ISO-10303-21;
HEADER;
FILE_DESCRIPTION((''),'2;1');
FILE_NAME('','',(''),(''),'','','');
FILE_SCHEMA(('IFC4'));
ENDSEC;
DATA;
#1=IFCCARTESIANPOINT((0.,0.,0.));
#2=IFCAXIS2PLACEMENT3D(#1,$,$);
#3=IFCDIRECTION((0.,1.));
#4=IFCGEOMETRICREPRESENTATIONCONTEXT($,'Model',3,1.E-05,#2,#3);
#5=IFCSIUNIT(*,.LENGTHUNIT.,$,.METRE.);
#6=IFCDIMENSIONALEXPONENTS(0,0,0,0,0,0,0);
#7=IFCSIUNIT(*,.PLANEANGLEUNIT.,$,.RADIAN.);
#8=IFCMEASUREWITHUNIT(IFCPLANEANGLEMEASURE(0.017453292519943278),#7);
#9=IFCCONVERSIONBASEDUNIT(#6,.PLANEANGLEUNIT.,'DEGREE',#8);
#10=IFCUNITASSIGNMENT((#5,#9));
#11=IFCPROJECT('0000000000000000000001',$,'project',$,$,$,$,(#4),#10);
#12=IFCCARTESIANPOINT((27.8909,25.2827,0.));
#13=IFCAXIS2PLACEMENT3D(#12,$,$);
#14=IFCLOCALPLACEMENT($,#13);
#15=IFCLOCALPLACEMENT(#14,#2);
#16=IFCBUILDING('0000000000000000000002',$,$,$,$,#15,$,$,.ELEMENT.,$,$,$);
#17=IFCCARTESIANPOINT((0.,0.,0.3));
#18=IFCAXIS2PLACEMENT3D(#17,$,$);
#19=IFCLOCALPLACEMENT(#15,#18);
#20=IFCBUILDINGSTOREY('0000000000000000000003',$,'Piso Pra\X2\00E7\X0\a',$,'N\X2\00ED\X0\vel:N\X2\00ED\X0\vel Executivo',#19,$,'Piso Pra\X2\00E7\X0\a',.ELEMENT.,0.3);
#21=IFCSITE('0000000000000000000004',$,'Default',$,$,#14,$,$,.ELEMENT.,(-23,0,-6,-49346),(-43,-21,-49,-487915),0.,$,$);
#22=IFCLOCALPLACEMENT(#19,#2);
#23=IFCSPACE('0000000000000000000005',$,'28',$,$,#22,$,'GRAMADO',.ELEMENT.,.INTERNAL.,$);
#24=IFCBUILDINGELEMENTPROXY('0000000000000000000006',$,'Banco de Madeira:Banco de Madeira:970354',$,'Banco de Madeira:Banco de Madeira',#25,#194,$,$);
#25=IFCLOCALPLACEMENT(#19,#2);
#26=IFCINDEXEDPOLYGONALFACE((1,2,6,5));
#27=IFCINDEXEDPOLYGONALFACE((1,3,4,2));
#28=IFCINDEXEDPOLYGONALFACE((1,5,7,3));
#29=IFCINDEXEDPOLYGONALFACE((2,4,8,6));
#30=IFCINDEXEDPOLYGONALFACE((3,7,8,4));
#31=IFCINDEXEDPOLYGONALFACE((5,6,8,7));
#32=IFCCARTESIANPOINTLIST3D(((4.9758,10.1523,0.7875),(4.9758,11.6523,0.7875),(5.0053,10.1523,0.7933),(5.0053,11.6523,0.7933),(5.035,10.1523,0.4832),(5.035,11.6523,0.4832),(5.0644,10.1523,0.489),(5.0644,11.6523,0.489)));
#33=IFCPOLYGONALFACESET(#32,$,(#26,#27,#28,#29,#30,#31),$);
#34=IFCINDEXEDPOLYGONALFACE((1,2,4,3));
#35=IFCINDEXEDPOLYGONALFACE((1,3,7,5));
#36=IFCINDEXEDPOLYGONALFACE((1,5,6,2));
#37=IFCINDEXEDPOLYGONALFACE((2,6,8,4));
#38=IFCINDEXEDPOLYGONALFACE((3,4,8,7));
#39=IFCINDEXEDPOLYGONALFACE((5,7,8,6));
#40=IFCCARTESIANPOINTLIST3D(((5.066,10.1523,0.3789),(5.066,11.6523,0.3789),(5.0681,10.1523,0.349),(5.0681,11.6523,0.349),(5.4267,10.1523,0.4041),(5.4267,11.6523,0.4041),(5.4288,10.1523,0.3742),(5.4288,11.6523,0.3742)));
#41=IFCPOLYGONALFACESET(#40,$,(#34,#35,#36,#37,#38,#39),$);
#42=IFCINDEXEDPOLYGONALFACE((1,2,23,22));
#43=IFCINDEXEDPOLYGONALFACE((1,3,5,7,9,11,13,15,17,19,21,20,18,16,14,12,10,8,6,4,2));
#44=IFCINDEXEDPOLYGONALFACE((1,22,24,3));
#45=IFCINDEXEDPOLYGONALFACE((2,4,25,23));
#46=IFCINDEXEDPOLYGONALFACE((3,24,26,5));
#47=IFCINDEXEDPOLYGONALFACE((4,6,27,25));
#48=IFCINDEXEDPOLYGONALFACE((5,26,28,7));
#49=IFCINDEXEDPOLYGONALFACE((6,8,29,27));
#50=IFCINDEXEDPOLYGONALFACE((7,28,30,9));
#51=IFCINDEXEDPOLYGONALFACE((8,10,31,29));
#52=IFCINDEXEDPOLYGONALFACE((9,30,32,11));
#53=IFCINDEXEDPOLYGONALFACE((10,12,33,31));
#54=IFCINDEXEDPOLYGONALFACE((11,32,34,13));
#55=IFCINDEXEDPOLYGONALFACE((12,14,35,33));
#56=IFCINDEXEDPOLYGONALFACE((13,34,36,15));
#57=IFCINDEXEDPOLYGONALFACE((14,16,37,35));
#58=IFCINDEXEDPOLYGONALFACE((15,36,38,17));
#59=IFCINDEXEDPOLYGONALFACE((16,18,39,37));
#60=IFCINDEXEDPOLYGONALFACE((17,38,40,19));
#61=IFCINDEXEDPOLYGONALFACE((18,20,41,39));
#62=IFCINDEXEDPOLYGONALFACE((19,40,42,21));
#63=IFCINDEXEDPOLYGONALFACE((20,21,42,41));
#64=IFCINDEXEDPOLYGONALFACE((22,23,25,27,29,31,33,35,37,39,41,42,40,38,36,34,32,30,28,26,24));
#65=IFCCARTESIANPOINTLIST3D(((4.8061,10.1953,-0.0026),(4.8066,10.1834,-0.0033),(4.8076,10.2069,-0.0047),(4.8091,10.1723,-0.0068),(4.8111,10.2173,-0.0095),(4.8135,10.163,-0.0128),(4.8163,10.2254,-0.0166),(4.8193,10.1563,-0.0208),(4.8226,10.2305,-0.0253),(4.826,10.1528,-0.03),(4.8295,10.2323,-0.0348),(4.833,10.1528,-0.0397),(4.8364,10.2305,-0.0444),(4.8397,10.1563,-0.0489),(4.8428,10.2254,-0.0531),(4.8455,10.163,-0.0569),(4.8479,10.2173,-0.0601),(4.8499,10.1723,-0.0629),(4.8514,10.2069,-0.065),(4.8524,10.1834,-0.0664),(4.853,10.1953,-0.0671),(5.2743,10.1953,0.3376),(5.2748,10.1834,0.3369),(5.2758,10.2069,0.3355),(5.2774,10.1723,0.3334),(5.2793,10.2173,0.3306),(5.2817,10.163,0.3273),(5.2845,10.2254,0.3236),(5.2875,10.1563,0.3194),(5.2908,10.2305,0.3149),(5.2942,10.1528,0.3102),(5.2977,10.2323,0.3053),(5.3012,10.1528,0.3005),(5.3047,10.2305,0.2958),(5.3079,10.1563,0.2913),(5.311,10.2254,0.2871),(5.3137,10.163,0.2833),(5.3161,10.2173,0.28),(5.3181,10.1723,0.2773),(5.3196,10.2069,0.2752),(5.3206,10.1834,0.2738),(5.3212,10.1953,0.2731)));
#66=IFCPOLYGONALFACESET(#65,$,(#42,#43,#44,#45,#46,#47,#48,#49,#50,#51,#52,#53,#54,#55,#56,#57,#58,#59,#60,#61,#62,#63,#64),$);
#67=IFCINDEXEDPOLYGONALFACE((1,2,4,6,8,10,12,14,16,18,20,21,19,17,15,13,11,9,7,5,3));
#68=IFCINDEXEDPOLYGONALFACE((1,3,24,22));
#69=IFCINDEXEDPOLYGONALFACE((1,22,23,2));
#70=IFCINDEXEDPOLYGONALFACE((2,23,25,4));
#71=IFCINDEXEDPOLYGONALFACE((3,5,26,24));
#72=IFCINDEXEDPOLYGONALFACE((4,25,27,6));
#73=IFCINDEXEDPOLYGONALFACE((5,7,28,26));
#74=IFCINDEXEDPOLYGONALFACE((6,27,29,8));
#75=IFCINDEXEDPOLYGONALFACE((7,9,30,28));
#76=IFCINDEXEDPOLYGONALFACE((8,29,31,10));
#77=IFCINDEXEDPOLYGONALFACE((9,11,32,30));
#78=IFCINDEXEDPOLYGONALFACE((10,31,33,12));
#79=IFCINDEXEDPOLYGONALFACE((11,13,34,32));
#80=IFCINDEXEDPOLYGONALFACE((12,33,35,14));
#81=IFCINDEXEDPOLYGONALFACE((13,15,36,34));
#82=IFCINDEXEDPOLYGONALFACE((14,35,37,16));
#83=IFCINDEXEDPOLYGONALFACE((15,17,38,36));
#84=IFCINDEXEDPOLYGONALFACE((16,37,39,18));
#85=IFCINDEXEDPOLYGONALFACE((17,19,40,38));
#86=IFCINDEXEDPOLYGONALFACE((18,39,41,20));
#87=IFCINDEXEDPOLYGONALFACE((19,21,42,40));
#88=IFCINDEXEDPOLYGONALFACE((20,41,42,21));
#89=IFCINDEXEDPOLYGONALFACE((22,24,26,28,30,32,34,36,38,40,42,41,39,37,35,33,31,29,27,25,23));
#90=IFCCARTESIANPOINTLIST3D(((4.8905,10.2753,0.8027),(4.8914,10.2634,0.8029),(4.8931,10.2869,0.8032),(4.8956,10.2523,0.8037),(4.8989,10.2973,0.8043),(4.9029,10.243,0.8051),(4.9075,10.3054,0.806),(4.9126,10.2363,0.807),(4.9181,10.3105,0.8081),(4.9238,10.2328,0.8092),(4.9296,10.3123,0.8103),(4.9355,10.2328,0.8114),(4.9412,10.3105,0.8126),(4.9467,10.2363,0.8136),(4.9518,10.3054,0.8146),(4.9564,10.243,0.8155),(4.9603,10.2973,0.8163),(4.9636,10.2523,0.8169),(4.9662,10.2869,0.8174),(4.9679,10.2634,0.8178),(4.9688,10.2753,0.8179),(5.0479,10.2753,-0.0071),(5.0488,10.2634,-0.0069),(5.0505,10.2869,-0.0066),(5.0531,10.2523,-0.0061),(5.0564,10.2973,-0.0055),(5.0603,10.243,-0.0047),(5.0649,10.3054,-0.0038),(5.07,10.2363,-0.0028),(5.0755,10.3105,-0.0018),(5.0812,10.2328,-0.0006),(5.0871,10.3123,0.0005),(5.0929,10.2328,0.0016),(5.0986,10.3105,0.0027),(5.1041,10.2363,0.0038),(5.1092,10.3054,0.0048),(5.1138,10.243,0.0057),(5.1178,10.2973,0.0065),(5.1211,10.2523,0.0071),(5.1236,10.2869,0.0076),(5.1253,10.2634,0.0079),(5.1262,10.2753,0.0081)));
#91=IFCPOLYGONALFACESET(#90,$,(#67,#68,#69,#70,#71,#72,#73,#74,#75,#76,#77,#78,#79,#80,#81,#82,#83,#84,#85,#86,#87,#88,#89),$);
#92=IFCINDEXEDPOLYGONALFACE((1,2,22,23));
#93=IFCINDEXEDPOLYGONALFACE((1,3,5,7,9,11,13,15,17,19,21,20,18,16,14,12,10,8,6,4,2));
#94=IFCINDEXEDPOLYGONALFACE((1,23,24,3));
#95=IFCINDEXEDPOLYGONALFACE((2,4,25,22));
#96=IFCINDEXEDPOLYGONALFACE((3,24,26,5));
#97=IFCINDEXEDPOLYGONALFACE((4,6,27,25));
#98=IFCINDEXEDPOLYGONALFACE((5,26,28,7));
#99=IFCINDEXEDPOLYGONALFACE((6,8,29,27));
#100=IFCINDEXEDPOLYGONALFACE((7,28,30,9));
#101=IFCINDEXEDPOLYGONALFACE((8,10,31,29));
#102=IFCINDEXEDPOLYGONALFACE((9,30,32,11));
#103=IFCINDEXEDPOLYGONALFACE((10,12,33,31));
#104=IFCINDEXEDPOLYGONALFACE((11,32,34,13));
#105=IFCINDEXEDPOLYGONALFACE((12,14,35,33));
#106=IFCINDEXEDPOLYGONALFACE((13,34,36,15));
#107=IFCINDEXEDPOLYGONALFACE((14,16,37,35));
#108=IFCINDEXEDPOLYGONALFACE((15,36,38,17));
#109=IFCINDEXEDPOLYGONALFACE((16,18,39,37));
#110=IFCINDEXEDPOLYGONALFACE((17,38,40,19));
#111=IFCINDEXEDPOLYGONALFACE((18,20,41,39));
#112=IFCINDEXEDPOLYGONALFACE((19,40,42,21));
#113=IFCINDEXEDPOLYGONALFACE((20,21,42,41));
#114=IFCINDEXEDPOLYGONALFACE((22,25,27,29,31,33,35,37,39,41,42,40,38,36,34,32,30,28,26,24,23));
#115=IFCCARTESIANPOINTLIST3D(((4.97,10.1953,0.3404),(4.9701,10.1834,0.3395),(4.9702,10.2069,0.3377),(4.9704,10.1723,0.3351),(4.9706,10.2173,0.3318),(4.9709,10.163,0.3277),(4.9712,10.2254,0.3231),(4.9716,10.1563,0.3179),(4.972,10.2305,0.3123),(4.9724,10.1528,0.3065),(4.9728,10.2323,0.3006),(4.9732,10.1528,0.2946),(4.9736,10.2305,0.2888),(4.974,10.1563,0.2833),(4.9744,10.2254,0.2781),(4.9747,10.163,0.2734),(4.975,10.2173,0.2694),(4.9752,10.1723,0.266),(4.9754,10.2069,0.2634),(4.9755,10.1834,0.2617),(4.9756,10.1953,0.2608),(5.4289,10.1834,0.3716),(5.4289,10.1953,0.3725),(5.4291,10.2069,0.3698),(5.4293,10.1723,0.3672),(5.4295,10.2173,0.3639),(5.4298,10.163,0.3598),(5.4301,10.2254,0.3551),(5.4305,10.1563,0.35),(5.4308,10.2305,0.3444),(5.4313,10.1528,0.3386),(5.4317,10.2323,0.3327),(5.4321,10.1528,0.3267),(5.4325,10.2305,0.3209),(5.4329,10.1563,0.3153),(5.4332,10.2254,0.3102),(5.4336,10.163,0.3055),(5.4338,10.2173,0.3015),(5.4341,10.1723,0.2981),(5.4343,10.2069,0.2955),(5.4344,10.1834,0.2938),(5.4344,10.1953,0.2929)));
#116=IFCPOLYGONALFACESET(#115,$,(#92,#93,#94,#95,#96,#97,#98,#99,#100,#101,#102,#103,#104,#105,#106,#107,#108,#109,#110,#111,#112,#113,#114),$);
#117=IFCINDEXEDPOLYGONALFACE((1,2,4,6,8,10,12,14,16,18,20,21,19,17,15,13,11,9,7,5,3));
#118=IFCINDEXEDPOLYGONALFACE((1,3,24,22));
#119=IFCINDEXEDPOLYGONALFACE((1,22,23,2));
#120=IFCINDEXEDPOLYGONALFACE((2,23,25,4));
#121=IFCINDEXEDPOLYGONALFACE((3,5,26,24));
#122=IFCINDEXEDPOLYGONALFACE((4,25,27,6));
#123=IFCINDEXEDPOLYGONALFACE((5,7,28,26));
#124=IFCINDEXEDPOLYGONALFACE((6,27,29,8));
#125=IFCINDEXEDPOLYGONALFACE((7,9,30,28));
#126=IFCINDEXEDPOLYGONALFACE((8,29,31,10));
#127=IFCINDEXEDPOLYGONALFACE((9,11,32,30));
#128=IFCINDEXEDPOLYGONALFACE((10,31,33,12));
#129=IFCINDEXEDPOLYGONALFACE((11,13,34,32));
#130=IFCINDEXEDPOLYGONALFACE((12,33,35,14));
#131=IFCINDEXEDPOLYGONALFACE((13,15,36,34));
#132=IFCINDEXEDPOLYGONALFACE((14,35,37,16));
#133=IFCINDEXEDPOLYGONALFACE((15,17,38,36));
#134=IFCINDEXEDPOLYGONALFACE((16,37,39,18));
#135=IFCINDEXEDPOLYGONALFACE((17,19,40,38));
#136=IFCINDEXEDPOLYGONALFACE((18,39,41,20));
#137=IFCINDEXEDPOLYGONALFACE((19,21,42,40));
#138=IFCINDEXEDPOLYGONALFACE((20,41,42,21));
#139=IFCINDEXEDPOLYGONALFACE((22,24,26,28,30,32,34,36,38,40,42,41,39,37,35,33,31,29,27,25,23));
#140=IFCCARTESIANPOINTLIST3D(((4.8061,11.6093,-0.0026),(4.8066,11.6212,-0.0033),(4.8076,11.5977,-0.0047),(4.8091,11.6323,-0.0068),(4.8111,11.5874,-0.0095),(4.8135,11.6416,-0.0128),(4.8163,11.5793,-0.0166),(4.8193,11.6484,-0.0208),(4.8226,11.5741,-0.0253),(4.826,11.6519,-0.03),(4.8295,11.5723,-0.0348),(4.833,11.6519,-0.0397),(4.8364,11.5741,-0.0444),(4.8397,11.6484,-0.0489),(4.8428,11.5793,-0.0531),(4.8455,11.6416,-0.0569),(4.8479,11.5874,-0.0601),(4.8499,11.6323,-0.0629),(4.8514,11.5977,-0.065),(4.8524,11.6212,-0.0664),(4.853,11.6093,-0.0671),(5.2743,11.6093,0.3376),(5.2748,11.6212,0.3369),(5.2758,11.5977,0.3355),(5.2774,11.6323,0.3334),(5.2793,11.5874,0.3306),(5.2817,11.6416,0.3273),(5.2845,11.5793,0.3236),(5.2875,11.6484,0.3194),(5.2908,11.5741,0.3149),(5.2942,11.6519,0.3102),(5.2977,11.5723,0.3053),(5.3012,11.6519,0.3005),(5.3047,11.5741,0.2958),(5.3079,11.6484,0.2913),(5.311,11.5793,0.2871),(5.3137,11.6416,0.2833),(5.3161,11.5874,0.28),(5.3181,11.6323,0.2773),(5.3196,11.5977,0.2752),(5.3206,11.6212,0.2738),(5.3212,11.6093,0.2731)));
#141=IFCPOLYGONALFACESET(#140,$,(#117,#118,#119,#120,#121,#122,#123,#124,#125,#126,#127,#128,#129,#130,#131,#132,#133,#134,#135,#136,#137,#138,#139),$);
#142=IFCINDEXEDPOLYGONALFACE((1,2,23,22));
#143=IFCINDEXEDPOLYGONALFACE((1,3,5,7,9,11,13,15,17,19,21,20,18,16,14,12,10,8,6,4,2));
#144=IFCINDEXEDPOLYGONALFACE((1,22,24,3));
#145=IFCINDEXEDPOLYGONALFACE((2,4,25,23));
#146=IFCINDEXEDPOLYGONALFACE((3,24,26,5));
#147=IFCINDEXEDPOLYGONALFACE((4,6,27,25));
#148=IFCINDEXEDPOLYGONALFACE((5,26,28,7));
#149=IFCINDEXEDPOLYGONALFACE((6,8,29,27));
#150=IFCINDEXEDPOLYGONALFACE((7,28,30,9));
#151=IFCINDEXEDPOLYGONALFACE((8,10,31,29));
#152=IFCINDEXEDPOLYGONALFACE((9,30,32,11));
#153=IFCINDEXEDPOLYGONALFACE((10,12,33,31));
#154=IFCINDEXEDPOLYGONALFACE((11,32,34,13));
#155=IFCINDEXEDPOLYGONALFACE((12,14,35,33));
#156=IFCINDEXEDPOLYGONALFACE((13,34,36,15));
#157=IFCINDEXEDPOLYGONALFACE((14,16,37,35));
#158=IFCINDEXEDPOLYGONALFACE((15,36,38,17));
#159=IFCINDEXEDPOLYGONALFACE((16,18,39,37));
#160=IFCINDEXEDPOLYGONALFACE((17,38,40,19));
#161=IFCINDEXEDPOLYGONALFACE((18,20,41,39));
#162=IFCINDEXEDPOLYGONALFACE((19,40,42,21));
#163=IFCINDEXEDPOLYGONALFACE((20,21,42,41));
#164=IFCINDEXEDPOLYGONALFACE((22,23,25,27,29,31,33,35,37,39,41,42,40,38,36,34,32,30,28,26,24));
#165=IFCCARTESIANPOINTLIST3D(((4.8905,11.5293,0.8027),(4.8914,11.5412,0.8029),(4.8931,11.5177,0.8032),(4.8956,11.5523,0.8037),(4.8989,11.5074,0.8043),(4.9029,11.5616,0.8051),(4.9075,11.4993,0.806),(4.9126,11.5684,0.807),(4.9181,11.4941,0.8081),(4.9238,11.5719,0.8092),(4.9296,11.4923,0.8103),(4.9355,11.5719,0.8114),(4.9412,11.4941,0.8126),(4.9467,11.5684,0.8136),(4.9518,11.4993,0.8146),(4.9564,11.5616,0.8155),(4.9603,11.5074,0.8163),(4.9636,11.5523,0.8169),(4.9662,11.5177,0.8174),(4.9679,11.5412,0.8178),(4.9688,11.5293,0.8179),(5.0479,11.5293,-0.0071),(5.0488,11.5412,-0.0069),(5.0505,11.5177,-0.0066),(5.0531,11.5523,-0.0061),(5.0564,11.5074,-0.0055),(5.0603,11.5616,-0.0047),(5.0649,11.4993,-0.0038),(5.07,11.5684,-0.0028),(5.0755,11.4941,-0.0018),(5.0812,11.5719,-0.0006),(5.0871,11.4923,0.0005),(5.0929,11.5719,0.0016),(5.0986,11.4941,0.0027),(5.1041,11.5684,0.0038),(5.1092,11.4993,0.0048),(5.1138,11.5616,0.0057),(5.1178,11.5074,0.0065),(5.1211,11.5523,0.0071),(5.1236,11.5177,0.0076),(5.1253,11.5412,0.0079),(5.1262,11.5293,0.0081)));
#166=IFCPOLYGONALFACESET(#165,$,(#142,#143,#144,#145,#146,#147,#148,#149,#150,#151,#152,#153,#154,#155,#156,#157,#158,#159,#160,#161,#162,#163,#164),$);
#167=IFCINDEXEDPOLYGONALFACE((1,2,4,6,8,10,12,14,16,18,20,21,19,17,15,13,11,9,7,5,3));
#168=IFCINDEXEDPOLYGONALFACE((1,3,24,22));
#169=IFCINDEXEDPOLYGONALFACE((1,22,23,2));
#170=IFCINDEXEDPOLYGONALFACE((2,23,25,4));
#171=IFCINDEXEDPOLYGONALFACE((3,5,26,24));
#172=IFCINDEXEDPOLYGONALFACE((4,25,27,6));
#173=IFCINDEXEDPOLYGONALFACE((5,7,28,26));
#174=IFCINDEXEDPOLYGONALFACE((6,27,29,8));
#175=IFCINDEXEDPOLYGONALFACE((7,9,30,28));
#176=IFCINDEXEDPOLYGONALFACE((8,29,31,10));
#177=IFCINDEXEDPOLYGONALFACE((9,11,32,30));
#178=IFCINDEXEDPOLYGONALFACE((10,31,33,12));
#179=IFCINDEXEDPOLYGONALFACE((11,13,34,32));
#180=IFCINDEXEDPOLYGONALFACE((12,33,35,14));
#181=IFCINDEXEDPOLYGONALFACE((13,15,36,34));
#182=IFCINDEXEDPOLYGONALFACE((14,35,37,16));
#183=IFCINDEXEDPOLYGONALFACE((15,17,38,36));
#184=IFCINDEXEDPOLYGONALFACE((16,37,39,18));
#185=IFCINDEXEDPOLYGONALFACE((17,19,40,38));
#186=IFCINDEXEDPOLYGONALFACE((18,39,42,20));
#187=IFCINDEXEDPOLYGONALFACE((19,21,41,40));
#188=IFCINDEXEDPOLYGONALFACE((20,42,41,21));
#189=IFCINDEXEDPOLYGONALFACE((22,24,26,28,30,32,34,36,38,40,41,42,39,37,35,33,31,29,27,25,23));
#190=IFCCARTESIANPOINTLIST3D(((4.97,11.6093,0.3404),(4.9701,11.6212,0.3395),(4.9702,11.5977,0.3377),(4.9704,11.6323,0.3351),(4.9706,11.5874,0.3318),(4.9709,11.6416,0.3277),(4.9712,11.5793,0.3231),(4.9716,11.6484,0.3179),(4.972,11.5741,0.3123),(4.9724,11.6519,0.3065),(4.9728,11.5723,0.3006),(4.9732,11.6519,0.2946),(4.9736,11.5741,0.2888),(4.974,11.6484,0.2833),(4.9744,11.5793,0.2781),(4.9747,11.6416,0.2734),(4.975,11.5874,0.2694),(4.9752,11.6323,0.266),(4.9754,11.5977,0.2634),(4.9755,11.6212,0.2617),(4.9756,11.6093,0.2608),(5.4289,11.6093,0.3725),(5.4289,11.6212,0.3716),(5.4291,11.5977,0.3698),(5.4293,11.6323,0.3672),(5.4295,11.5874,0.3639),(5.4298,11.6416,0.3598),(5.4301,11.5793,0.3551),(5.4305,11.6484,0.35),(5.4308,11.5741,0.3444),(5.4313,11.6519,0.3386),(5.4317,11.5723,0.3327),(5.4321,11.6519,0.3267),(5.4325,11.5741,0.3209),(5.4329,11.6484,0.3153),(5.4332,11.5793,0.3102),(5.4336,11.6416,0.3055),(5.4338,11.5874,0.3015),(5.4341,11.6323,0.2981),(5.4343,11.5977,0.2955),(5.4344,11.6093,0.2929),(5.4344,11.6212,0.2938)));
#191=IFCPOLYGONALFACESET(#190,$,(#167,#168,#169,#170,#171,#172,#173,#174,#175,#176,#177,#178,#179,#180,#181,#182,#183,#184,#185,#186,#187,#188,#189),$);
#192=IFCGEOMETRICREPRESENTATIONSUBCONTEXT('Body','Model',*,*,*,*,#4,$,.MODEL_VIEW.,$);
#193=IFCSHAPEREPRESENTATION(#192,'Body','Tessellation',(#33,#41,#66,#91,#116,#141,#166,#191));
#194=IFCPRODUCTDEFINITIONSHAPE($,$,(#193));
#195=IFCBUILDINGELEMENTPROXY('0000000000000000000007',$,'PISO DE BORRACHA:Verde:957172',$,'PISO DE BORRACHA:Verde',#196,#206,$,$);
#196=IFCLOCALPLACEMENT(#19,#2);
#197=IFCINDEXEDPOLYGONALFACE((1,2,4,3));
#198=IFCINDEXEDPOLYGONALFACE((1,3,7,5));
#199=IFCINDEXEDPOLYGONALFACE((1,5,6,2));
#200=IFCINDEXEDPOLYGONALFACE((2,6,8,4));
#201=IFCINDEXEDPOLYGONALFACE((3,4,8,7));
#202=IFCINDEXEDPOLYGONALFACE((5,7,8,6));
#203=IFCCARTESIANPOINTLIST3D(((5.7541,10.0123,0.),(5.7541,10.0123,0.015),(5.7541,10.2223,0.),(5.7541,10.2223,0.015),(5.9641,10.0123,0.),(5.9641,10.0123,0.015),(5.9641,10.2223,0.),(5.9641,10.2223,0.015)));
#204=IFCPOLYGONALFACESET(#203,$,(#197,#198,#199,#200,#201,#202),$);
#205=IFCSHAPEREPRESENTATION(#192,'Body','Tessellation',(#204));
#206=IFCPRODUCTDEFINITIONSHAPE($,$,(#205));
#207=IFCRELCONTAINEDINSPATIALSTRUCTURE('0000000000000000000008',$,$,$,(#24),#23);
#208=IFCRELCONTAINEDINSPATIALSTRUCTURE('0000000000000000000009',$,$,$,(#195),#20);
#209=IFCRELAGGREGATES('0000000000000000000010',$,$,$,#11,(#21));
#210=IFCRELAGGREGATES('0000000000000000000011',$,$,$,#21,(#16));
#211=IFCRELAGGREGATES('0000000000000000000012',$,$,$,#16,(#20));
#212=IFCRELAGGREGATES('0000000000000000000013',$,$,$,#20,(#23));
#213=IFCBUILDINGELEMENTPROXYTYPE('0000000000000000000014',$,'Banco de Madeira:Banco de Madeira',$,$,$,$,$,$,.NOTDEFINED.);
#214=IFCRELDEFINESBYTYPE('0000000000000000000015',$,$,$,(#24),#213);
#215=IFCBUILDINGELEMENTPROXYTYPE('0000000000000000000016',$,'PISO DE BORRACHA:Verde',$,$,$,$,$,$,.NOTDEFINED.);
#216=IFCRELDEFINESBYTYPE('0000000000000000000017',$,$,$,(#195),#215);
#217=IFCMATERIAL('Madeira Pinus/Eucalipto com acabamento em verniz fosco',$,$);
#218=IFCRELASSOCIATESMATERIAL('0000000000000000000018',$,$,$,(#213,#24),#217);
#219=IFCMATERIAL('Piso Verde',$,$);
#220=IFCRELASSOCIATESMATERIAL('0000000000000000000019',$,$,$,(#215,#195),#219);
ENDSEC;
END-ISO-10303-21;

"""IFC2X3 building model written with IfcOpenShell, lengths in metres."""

from ifc_helpers import new_model, entity, si_unit, converted_unit, direction, frame, frame_2d, origin, origin_2d_with_axis, place, context, subcontext, project, spatial, rectangle, circle, extrude, source, transform, mapped, material, type_object, type_shapes, element, save


model = new_model("IFC2X3")

# Units and contexts
model_context = context("Model", 3, precision=1e-05, world=origin(), true_north=direction((0.0, 1.0)))
body_context = subcontext(model_context, "Body", "Model", "MODEL_VIEW")
ifc_project = project(units=[si_unit("LENGTHUNIT", "METRE"), converted_unit("PLANEANGLEUNIT", "DEGREE", entity("IfcPlaneAngleMeasure", 0.017453292519943278), si_unit("PLANEANGLEUNIT", "RADIAN"), dimensions=[0, 0, 0, 0, 0, 0, 0])], contexts=[model_context])

# Site, building, storey
site_placement = place(None, frame((27.8909, 25.2827, 0.0)))
site = spatial("IfcSite", under=ifc_project, at=site_placement, Name="Default", CompositionType="ELEMENT", RefLatitude=(-23, 0, -6, -49346), RefLongitude=(-43, -21, -49, -487915), RefElevation=0.0)
building_placement = place(site_placement, origin())
building = spatial("IfcBuilding", under=site, at=building_placement, CompositionType="ELEMENT")
storey_placement = place(building_placement, frame((0.0, 0.0, 0.3)))
storey = spatial("IfcBuildingStorey", under=building, at=storey_placement, Name="Piso Praça", ObjectType="Nível:Nível Executivo", LongName="Piso Praça", CompositionType="ELEMENT", Elevation=0.3)

# Shared definitions
space_placement = place(storey_placement, origin())
space = spatial("IfcSpace", under=storey, at=space_placement, Name="28", LongName="GRAMADO", CompositionType="ELEMENT", InteriorOrExteriorSpace="INTERNAL")

# Building element proxies
ifc_material_1 = material(Name="Madeira Pinus/Eucalipto com acabamento em verniz fosco")
building_element_proxy_type_1 = type_object("IfcBuildingElementProxyType", Name="Banco de Madeira:Banco de Madeira", PredefinedType="NOTDEFINED", material=ifc_material_1)
shared_shape_1 = source(origin(), body_context, "Body", "SweptSolid", [
    extrude(rectangle(XDim=0.31, YDim=0.03, at=frame_2d((0.0, 0.0), x_axis=(0.0, 1.0))), frame((-0.75, -0.1439, 0.6383), z_axis=(1.0, 0.0, 0.0), x_axis=(0.0, 0.981627, 0.190809)), (0.0, 0.0, 1.0), 1.5),
    extrude(rectangle(XDim=0.03, YDim=0.3616, at=frame_2d((0.0, 0.0), x_axis=(1.0, 0.0))), frame((-0.75, 0.0833, 0.3765), z_axis=(1.0, 0.0, 0.0), x_axis=(0.0, -0.069756, 0.997564)), (0.0, 0.0, 1.0), 1.5),
    extrude(circle(Radius=0.04, at=frame_2d((0.0, 0.0), x_axis=(1.0, 0.0))), frame((0.71, -0.3345, -0.0348), z_axis=(0.0, 0.809017, 0.587785), x_axis=(-1.0, 0.0, 0.0)), (0.0, 0.0, 1.0), 0.5788),
    extrude(circle(Radius=0.04, at=frame_2d((0.0, 0.0), x_axis=(1.0, 0.0))), frame((0.63, -0.2344, 0.8103), z_axis=(0.0, 0.190809, -0.981627), x_axis=(-1.0, 0.0, 0.0)), (0.0, 0.0, 1.0), 0.825),
    extrude(circle(Radius=0.04, at=frame_2d((0.0, 0.0), x_axis=(1.0, 0.0))), frame((0.71, -0.1913, 0.3006), z_axis=(0.0, 0.997564, 0.069756), x_axis=(-1.0, 0.0, 0.0)), (0.0, 0.0, 1.0), 0.46),
    extrude(circle(Radius=0.04, at=frame_2d((0.0, 0.0), x_axis=(1.0, 0.0))), frame((-0.71, -0.3345, -0.0348), z_axis=(0.0, 0.809017, 0.587785), x_axis=(1.0, 0.0, 0.0)), (0.0, 0.0, 1.0), 0.5788),
    extrude(circle(Radius=0.04, at=frame_2d((0.0, 0.0), x_axis=(1.0, 0.0))), frame((-0.63, -0.2344, 0.8103), z_axis=(0.0, 0.190809, -0.981627), x_axis=(1.0, 0.0, 0.0)), (0.0, 0.0, 1.0), 0.825),
    extrude(circle(Radius=0.04, at=frame_2d((0.0, 0.0), x_axis=(1.0, 0.0))), frame((-0.71, -0.1913, 0.3006), z_axis=(0.0, 0.997564, 0.069756), x_axis=(1.0, 0.0, 0.0)), (0.0, 0.0, 1.0), 0.46),
])
type_shapes(building_element_proxy_type_1, [shared_shape_1])
proxy_1_placement = place(space_placement, frame((5.1641, 10.9023, 0.0), z_axis=(0.0, 0.0, 1.0), x_axis=(0.0, -1.0, 0.0)))
element("IfcBuildingElementProxy", 1, at=proxy_1_placement, inside=space, type_object=building_element_proxy_type_1, material=ifc_material_1, Name="Banco de Madeira:Banco de Madeira:970354", ObjectType="Banco de Madeira:Banco de Madeira", context=body_context, shape_type="MappedRepresentation", body=[
    mapped(shared_shape_1, transform((0.0, 0.0, 0.0), scale=1.0)),
])
ifc_material_2 = material(Name="Piso Verde")
building_element_proxy_type_2 = type_object("IfcBuildingElementProxyType", Name="PISO DE BORRACHA:Verde", PredefinedType="NOTDEFINED", material=ifc_material_2)
shared_shape_2 = source(origin(), body_context, "Body", "SweptSolid", [
    extrude(rectangle(XDim=0.21, YDim=0.21, at=origin_2d_with_axis()), frame((0.105, 0.105, 0.0), z_axis=(0.0, 0.0, 1.0), x_axis=(-1.0, 0.0, 0.0)), (0.0, 0.0, 1.0), 0.015),
])
type_shapes(building_element_proxy_type_2, [shared_shape_2])
proxy_2_placement = place(storey_placement, frame((5.7541, 10.0123, 0.0)))
element("IfcBuildingElementProxy", 2, at=proxy_2_placement, inside=storey, type_object=building_element_proxy_type_2, material=ifc_material_2, Name="PISO DE BORRACHA:Verde:957172", ObjectType="PISO DE BORRACHA:Verde", context=body_context, shape_type="MappedRepresentation", body=[
    mapped(shared_shape_2, transform((0.0, 0.0, 0.0), scale=1.0)),
])

save(model, "model.ifc")
